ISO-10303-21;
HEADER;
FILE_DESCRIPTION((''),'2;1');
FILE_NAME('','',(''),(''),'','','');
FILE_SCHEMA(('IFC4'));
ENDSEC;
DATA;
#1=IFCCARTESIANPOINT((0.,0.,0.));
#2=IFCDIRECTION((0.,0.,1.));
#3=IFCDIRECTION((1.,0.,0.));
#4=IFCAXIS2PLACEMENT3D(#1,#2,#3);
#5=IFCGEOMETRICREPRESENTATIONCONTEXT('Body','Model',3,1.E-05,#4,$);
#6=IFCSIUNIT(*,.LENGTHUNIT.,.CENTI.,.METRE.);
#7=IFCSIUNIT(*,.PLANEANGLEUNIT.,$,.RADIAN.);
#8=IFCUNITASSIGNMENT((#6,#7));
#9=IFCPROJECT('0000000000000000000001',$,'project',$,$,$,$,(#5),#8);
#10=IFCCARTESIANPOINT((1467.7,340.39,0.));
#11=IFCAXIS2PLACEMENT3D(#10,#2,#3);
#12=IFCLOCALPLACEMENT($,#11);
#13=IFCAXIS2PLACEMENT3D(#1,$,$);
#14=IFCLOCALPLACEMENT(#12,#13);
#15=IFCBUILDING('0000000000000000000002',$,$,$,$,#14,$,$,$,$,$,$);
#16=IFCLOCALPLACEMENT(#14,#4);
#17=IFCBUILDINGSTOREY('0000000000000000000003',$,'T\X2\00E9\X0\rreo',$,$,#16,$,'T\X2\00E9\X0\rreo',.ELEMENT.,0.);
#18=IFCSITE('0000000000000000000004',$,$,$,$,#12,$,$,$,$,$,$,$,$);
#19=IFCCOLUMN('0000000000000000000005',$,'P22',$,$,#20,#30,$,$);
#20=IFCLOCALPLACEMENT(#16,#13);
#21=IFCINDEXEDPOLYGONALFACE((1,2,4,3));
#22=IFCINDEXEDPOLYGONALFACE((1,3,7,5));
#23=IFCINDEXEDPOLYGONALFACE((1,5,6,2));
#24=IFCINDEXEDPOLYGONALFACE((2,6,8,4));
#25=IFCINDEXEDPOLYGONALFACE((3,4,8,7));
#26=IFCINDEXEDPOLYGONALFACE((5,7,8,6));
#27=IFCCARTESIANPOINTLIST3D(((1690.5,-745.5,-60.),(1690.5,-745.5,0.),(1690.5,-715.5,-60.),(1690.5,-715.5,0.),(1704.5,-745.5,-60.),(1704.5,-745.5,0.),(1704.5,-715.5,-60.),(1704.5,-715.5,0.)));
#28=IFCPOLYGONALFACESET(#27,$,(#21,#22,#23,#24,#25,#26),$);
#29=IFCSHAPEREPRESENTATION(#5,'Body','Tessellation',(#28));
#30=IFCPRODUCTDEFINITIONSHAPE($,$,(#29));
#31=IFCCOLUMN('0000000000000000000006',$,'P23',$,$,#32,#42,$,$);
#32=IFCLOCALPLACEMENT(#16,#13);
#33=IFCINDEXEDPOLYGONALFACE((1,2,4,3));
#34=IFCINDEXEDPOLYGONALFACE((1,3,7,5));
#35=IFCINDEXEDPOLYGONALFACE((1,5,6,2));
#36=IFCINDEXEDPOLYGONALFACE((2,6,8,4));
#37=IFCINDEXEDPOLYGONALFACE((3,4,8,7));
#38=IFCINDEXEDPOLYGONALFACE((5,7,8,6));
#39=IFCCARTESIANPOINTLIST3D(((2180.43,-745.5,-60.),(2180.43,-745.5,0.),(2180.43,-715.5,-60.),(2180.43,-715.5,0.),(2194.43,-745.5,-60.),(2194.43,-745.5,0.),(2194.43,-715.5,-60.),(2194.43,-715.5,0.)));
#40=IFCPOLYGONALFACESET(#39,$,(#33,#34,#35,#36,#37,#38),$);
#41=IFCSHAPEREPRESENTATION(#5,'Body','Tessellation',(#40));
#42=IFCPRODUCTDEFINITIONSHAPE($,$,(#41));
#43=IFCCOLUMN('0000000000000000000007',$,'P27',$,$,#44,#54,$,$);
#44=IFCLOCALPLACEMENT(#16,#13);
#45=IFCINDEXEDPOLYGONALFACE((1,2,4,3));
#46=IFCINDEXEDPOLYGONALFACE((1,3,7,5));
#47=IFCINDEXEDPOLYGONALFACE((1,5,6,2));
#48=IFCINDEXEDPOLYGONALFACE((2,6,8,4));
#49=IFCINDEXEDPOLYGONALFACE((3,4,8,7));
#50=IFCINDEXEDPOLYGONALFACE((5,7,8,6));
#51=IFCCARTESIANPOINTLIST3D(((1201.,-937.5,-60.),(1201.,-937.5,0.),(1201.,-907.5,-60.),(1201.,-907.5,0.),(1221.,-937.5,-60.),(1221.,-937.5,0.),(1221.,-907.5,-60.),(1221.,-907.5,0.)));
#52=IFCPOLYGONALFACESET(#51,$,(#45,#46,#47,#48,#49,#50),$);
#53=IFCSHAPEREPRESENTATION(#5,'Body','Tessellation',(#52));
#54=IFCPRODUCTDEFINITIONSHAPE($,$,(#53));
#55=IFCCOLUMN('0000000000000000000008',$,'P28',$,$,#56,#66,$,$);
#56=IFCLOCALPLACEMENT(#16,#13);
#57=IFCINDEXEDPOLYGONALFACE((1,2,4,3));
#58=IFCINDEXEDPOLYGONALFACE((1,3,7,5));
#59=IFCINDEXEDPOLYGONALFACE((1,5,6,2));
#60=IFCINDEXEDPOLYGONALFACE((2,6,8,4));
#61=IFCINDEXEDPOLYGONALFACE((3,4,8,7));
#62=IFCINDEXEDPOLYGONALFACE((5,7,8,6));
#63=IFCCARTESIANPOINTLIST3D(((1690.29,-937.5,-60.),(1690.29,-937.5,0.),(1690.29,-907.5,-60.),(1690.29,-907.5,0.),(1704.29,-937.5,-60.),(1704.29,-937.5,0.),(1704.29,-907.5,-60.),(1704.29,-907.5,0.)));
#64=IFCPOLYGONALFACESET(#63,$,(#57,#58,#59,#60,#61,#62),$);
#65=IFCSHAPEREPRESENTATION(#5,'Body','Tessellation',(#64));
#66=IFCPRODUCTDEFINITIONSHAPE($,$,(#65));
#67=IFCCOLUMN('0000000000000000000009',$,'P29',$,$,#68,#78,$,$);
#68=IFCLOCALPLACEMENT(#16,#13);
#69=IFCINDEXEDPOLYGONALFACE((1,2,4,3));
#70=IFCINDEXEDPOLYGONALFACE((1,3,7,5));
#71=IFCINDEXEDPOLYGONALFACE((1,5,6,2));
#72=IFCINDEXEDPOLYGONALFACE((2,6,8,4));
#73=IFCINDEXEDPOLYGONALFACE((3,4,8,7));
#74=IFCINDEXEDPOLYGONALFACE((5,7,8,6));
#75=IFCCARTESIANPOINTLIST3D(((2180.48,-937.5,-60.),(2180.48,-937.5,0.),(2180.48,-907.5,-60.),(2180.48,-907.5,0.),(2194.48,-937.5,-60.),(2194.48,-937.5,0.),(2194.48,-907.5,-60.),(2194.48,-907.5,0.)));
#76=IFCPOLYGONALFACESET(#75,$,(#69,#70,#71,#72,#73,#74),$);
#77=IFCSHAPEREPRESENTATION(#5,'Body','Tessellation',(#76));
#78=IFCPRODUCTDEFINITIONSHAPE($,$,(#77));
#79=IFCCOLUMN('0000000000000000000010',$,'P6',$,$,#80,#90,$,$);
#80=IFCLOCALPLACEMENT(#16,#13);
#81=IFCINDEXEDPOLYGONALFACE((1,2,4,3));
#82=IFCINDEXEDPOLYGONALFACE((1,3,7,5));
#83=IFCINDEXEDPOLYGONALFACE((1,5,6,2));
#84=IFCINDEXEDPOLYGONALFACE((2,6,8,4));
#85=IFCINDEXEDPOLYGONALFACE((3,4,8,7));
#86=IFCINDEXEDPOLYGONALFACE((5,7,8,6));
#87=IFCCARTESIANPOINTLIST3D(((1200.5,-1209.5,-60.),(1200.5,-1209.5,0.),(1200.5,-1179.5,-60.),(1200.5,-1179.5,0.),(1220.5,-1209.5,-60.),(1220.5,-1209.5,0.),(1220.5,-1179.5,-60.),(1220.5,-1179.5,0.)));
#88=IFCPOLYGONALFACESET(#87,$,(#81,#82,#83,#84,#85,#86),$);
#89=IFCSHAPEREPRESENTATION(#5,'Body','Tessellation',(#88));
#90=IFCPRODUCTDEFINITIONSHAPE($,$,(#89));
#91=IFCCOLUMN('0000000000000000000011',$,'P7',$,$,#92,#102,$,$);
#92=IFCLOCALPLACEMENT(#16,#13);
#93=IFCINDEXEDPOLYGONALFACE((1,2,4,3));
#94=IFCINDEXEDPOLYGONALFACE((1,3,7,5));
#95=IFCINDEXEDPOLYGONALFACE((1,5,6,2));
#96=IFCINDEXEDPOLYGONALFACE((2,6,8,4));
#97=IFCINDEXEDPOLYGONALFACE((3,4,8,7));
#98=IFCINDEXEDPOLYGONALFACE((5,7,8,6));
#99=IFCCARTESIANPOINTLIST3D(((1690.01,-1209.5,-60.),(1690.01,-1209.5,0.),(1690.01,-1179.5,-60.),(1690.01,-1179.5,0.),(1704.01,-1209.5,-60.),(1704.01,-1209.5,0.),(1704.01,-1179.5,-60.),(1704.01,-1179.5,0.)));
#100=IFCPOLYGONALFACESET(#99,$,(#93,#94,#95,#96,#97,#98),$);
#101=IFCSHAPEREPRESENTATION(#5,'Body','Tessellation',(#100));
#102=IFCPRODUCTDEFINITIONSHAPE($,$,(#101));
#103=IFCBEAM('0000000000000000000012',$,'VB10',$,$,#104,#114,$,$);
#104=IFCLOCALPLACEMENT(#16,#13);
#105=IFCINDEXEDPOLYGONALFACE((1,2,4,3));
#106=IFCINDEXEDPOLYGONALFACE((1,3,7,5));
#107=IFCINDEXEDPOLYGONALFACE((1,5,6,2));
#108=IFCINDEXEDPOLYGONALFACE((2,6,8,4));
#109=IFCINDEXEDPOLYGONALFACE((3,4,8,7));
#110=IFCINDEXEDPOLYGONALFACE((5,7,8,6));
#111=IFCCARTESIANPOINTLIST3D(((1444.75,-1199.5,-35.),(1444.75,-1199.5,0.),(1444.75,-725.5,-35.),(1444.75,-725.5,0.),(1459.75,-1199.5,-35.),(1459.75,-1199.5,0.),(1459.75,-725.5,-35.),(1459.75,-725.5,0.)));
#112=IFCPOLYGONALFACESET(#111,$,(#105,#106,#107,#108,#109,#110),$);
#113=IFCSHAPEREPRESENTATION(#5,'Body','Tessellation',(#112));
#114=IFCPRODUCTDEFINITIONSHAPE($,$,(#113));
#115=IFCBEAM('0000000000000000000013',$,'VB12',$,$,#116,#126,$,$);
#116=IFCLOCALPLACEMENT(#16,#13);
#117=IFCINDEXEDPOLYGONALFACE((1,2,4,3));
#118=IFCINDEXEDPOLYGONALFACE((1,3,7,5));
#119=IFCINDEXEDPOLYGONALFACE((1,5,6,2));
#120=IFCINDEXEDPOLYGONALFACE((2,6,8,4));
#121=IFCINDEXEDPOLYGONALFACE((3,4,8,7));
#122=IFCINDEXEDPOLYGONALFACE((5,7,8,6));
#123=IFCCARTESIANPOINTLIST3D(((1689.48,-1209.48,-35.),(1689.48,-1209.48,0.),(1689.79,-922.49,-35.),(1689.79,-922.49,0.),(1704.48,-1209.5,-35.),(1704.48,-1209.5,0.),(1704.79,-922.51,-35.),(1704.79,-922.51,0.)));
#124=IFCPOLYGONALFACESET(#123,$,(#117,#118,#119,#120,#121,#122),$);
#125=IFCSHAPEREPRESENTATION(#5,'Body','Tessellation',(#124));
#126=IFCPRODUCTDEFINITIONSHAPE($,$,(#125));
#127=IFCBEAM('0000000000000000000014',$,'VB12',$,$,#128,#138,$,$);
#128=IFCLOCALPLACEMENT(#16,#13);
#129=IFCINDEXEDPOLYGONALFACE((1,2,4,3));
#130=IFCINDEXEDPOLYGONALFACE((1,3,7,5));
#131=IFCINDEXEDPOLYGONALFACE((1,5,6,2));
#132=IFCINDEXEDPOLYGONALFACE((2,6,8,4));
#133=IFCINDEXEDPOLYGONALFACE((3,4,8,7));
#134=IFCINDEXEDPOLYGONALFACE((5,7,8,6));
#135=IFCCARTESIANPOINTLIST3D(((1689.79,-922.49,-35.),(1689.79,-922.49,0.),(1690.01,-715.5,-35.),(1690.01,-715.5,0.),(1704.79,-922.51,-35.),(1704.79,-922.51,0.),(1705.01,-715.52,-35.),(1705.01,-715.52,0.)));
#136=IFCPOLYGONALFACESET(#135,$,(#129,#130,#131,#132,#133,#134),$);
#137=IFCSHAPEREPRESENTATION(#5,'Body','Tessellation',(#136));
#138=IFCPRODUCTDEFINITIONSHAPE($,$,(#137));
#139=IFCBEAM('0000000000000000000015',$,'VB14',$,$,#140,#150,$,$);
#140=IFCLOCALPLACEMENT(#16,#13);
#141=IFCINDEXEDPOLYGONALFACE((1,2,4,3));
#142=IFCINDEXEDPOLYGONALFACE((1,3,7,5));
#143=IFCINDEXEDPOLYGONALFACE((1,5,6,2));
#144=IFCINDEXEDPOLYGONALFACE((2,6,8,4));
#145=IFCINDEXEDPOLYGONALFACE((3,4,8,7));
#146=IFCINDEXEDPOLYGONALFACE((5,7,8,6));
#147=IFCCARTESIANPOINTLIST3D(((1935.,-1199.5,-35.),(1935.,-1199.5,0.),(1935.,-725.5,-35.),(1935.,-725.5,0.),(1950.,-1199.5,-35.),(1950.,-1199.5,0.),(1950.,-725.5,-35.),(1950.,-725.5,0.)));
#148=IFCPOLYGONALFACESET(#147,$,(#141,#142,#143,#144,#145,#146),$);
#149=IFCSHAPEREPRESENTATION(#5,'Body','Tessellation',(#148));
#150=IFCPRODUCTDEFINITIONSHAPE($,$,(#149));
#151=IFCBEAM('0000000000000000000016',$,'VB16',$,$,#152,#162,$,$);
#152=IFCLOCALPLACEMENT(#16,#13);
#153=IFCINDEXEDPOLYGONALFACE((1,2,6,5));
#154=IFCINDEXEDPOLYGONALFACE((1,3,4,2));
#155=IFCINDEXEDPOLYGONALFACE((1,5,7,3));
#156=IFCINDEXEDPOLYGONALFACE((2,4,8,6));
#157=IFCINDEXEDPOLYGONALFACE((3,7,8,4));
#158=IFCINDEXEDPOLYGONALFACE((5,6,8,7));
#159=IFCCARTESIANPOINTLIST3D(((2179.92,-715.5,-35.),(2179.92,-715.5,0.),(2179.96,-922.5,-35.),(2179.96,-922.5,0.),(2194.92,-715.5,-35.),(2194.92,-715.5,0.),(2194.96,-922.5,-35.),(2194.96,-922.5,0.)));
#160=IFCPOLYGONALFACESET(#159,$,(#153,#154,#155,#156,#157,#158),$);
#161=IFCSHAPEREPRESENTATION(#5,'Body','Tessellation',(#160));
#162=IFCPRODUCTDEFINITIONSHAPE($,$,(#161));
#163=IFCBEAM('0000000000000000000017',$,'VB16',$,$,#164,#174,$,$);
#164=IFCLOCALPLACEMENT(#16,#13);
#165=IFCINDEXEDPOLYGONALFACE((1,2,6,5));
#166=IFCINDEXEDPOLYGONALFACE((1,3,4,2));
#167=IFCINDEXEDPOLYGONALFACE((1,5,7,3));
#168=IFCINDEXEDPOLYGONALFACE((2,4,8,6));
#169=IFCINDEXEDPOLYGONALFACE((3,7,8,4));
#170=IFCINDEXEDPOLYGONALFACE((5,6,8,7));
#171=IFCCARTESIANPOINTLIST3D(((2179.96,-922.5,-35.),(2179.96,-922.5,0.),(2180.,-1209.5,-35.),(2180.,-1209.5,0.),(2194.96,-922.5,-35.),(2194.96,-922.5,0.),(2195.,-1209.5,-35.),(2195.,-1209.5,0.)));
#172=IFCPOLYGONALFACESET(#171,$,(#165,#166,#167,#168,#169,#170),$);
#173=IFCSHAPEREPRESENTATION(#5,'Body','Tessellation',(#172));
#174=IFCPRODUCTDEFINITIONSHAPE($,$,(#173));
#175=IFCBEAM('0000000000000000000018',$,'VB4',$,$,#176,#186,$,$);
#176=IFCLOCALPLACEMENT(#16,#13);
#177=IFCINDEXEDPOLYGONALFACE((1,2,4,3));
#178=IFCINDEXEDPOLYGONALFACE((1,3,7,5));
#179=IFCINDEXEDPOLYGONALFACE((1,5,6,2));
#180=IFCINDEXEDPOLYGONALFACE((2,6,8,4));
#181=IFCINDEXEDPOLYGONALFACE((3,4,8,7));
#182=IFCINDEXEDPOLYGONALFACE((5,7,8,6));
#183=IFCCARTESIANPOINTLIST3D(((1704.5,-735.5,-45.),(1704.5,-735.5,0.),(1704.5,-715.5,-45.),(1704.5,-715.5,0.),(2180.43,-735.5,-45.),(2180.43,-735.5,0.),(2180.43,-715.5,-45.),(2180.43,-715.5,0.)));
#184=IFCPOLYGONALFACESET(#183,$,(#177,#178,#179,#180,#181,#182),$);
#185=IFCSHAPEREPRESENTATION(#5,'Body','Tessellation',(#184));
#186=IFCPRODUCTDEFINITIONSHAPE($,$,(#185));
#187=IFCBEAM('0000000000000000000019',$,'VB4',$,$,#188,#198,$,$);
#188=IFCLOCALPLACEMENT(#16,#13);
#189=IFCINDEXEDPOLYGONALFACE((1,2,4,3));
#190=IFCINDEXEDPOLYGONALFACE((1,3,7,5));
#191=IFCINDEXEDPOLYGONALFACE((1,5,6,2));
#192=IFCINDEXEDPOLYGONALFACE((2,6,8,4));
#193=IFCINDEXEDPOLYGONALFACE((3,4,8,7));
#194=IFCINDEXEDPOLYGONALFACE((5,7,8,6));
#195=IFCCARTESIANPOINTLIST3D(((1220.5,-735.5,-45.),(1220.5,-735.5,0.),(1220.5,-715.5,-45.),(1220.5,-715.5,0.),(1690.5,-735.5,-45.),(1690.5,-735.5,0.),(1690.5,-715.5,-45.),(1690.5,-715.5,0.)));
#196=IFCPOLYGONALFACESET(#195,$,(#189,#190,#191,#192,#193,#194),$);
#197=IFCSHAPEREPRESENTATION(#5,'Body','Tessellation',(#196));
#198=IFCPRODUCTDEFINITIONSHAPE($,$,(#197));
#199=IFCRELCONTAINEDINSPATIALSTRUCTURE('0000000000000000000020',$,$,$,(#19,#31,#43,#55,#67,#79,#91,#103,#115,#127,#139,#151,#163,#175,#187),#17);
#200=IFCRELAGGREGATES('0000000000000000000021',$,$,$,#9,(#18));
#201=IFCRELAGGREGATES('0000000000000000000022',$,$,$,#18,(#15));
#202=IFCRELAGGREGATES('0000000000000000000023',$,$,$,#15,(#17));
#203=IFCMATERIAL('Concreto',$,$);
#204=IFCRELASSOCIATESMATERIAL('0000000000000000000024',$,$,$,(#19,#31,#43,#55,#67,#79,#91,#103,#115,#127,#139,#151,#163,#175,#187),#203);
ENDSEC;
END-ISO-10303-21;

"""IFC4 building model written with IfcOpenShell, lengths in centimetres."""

from ifc_helpers import new_model, si_unit, frame, origin, origin_with_axes, origin_2d_with_axis, place, context, project, spatial, rectangle, extrude, material, element, save


model = new_model("IFC4")

# Units and contexts
model_context = context("Model", 3, precision=1e-05, world=origin_with_axes(), identifier="Body")
ifc_project = project(units=[si_unit("LENGTHUNIT", "METRE", prefix="CENTI"), si_unit("PLANEANGLEUNIT", "RADIAN")], contexts=[model_context])

# Site, building, storey
site_placement = place(None, frame((1467.7, 340.39, 0.0), z_axis=(0.0, 0.0, 1.0), x_axis=(1.0, 0.0, 0.0)))
site = spatial("IfcSite", under=ifc_project, at=site_placement)
building_placement = place(site_placement, origin())
building = spatial("IfcBuilding", under=site, at=building_placement)
storey_placement = place(building_placement, origin_with_axes())
storey = spatial("IfcBuildingStorey", under=building, at=storey_placement, Name="Térreo", LongName="Térreo", CompositionType="ELEMENT", Elevation=0.0)

# Columns
ifc_material = material(Name="Concreto")
column_1_placement = place(storey_placement, frame((1697.5, -730.5, 0.0), z_axis=(0.0, 0.0, 1.0), x_axis=(1.0, 0.0, 0.0)))
element("IfcColumn", 1, at=column_1_placement, inside=storey, material=ifc_material, Name="P22", context=model_context, shape_type="SolidModel", body=[
    extrude(rectangle(XDim=14.0, YDim=30.0, at=origin_2d_with_axis()), frame((0.0, 0.0, -60.0), z_axis=(0.0, 0.0, 1.0), x_axis=(-1.0, 0.0, 0.0)), (0.0, 0.0, 1.0), 60.0),
])
column_2_placement = place(storey_placement, frame((2187.43, -730.5, 0.0), z_axis=(0.0, 0.0, 1.0), x_axis=(1.0, 0.0, 0.0)))
element("IfcColumn", 2, at=column_2_placement, inside=storey, material=ifc_material, Name="P23", context=model_context, shape_type="SolidModel", body=[
    extrude(rectangle(XDim=14.0, YDim=30.0, at=origin_2d_with_axis()), frame((0.0, 0.0, -60.0), z_axis=(0.0, 0.0, 1.0), x_axis=(1.0, 0.0, 0.0)), (0.0, 0.0, 1.0), 60.0),
])
column_3_placement = place(storey_placement, frame((1211.0, -922.5, 0.0), z_axis=(0.0, 0.0, 1.0), x_axis=(1.0, 0.0, 0.0)))
element("IfcColumn", 3, at=column_3_placement, inside=storey, material=ifc_material, Name="P27", context=model_context, shape_type="SolidModel", body=[
    extrude(rectangle(XDim=20.0, YDim=30.0, at=origin_2d_with_axis()), frame((0.0, 0.0, -60.0), z_axis=(0.0, 0.0, 1.0), x_axis=(1.0, 0.0, 0.0)), (0.0, 0.0, 1.0), 60.0),
])
for number, where, z_axis, x_axis, name in (
    (4, (1697.29, -922.5, 0.0), (0.0, 0.0, 1.0), (1.0, 0.0, 0.0), "P28"),
    (5, (2187.48, -922.5, 0.0), (0.0, 0.0, 1.0), (1.0, 0.0, 0.0), "P29"),
):
    element("IfcColumn", number, at=place(storey_placement, frame(where, z_axis=z_axis, x_axis=x_axis)), inside=storey, material=ifc_material, Name=name, context=model_context, shape_type="SolidModel", body=[
        extrude(rectangle(XDim=14.0, YDim=30.0, at=origin_2d_with_axis()), frame((0.0, 0.0, -60.0), z_axis=(0.0, 0.0, 1.0), x_axis=(1.0, 0.0, 0.0)), (0.0, 0.0, 1.0), 60.0),
    ])
column_4_placement = place(storey_placement, frame((1210.5, -1194.5, 0.0), z_axis=(0.0, 0.0, 1.0), x_axis=(1.0, 0.0, 0.0)))
element("IfcColumn", 6, at=column_4_placement, inside=storey, material=ifc_material, Name="P6", context=model_context, shape_type="SolidModel", body=[
    extrude(rectangle(XDim=20.0, YDim=30.0, at=origin_2d_with_axis()), frame((0.0, 0.0, -60.0), z_axis=(0.0, 0.0, 1.0), x_axis=(1.0, 0.0, 0.0)), (0.0, 0.0, 1.0), 60.0),
])
column_5_placement = place(storey_placement, frame((1697.01, -1194.5, 0.0), z_axis=(0.0, 0.0, 1.0), x_axis=(1.0, 0.0, 0.0)))
element("IfcColumn", 7, at=column_5_placement, inside=storey, material=ifc_material, Name="P7", context=model_context, shape_type="SolidModel", body=[
    extrude(rectangle(XDim=14.0, YDim=30.0, at=origin_2d_with_axis()), frame((0.0, 0.0, -60.0), z_axis=(0.0, 0.0, 1.0), x_axis=(1.0, 0.0, 0.0)), (0.0, 0.0, 1.0), 60.0),
])

# Beams
beam_1_placement = place(storey_placement, frame((1452.25, -962.5, 0.0), z_axis=(0.0, 0.0, 1.0), x_axis=(1.0, 0.0, 0.0)))
element("IfcBeam", 8, at=beam_1_placement, inside=storey, material=ifc_material, Name="VB10", context=model_context, shape_type="SolidModel", body=[
    extrude(rectangle(XDim=15.0, YDim=35.0, at=origin_2d_with_axis()), frame((0.0, -237.0, -17.5), z_axis=(0.0, 1.0, 0.0), x_axis=(1.0, 0.0, 0.0)), (0.0, 0.0, 1.0), 474.0),
])
beam_2_placement = place(storey_placement, frame((1697.13, -1066.0, 0.0), z_axis=(0.0, 0.0, 1.0), x_axis=(1.0, 0.0, 0.0)))
element("IfcBeam", 9, at=beam_2_placement, inside=storey, material=ifc_material, Name="VB12", context=model_context, shape_type="SolidModel", body=[
    extrude(rectangle(XDim=15.0, YDim=35.0, at=origin_2d_with_axis()), frame((-0.15, -143.5, -17.5), z_axis=(0.001074, 1.0, 0.0), x_axis=(1.0, -0.001074, 0.0)), (0.0, 0.0, 1.0), 286.99),
])
beam_3_placement = place(storey_placement, frame((1697.4, -819.0, 0.0), z_axis=(0.0, 0.0, 1.0), x_axis=(1.0, 0.0, 0.0)))
element("IfcBeam", 10, at=beam_3_placement, inside=storey, material=ifc_material, Name="VB12", context=model_context, shape_type="SolidModel", body=[
    extrude(rectangle(XDim=15.0, YDim=35.0, at=origin_2d_with_axis()), frame((-0.11, -103.5, -17.5), z_axis=(0.001049, 1.0, 0.0), x_axis=(1.0, -0.001049, 0.0)), (0.0, 0.0, 1.0), 206.99),
])
beam_4_placement = place(storey_placement, frame((1942.5, -962.5, 0.0), z_axis=(0.0, 0.0, 1.0), x_axis=(1.0, 0.0, 0.0)))
element("IfcBeam", 11, at=beam_4_placement, inside=storey, material=ifc_material, Name="VB14", context=model_context, shape_type="SolidModel", body=[
    extrude(rectangle(XDim=15.0, YDim=35.0, at=origin_2d_with_axis()), frame((0.0, -237.0, -17.5), z_axis=(0.0, 1.0, 0.0), x_axis=(1.0, 0.0, 0.0)), (0.0, 0.0, 1.0), 474.0),
])
beam_5_placement = place(storey_placement, frame((2187.44, -819.0, 0.0), z_axis=(0.0, 0.0, 1.0), x_axis=(1.0, 0.0, 0.0)))
element("IfcBeam", 12, at=beam_5_placement, inside=storey, material=ifc_material, Name="VB16", context=model_context, shape_type="SolidModel", body=[
    extrude(rectangle(XDim=15.0, YDim=35.0, at=origin_2d_with_axis()), frame((0.02, -103.5, -17.5), z_axis=(-0.000185, 1.0, 0.0), x_axis=(1.0, 0.000185, 0.0)), (0.0, 0.0, 1.0), 207.0),
])
beam_6_placement = place(storey_placement, frame((2187.48, -1066.0, 0.0), z_axis=(0.0, 0.0, 1.0), x_axis=(1.0, 0.0, 0.0)))
element("IfcBeam", 13, at=beam_6_placement, inside=storey, material=ifc_material, Name="VB16", context=model_context, shape_type="SolidModel", body=[
    extrude(rectangle(XDim=15.0, YDim=35.0, at=origin_2d_with_axis()), frame((0.02, -143.5, -17.5), z_axis=(-0.000165, 1.0, 0.0), x_axis=(1.0, 0.000165, 0.0)), (0.0, 0.0, 1.0), 287.0),
])
beam_7_placement = place(storey_placement, frame((1942.46, -725.5, 0.0), z_axis=(0.0, 0.0, 1.0), x_axis=(1.0, 0.0, 0.0)))
element("IfcBeam", 14, at=beam_7_placement, inside=storey, material=ifc_material, Name="VB4", context=model_context, shape_type="SolidModel", body=[
    extrude(rectangle(XDim=20.0, YDim=45.0, at=origin_2d_with_axis()), frame((-237.97, 0.0, -22.5), z_axis=(1.0, 0.0, 0.0), x_axis=(0.0, 1.0, 0.0)), (0.0, 0.0, 1.0), 475.93),
])
beam_8_placement = place(storey_placement, frame((1455.5, -725.5, 0.0), z_axis=(0.0, 0.0, 1.0), x_axis=(1.0, 0.0, 0.0)))
element("IfcBeam", 15, at=beam_8_placement, inside=storey, material=ifc_material, Name="VB4", context=model_context, shape_type="SolidModel", body=[
    extrude(rectangle(XDim=20.0, YDim=45.0, at=origin_2d_with_axis()), frame((-235.0, 0.0, -22.5), z_axis=(1.0, 0.0, 0.0), x_axis=(0.0, 1.0, 0.0)), (0.0, 0.0, 1.0), 470.0),
])

save(model, "model.ifc")
